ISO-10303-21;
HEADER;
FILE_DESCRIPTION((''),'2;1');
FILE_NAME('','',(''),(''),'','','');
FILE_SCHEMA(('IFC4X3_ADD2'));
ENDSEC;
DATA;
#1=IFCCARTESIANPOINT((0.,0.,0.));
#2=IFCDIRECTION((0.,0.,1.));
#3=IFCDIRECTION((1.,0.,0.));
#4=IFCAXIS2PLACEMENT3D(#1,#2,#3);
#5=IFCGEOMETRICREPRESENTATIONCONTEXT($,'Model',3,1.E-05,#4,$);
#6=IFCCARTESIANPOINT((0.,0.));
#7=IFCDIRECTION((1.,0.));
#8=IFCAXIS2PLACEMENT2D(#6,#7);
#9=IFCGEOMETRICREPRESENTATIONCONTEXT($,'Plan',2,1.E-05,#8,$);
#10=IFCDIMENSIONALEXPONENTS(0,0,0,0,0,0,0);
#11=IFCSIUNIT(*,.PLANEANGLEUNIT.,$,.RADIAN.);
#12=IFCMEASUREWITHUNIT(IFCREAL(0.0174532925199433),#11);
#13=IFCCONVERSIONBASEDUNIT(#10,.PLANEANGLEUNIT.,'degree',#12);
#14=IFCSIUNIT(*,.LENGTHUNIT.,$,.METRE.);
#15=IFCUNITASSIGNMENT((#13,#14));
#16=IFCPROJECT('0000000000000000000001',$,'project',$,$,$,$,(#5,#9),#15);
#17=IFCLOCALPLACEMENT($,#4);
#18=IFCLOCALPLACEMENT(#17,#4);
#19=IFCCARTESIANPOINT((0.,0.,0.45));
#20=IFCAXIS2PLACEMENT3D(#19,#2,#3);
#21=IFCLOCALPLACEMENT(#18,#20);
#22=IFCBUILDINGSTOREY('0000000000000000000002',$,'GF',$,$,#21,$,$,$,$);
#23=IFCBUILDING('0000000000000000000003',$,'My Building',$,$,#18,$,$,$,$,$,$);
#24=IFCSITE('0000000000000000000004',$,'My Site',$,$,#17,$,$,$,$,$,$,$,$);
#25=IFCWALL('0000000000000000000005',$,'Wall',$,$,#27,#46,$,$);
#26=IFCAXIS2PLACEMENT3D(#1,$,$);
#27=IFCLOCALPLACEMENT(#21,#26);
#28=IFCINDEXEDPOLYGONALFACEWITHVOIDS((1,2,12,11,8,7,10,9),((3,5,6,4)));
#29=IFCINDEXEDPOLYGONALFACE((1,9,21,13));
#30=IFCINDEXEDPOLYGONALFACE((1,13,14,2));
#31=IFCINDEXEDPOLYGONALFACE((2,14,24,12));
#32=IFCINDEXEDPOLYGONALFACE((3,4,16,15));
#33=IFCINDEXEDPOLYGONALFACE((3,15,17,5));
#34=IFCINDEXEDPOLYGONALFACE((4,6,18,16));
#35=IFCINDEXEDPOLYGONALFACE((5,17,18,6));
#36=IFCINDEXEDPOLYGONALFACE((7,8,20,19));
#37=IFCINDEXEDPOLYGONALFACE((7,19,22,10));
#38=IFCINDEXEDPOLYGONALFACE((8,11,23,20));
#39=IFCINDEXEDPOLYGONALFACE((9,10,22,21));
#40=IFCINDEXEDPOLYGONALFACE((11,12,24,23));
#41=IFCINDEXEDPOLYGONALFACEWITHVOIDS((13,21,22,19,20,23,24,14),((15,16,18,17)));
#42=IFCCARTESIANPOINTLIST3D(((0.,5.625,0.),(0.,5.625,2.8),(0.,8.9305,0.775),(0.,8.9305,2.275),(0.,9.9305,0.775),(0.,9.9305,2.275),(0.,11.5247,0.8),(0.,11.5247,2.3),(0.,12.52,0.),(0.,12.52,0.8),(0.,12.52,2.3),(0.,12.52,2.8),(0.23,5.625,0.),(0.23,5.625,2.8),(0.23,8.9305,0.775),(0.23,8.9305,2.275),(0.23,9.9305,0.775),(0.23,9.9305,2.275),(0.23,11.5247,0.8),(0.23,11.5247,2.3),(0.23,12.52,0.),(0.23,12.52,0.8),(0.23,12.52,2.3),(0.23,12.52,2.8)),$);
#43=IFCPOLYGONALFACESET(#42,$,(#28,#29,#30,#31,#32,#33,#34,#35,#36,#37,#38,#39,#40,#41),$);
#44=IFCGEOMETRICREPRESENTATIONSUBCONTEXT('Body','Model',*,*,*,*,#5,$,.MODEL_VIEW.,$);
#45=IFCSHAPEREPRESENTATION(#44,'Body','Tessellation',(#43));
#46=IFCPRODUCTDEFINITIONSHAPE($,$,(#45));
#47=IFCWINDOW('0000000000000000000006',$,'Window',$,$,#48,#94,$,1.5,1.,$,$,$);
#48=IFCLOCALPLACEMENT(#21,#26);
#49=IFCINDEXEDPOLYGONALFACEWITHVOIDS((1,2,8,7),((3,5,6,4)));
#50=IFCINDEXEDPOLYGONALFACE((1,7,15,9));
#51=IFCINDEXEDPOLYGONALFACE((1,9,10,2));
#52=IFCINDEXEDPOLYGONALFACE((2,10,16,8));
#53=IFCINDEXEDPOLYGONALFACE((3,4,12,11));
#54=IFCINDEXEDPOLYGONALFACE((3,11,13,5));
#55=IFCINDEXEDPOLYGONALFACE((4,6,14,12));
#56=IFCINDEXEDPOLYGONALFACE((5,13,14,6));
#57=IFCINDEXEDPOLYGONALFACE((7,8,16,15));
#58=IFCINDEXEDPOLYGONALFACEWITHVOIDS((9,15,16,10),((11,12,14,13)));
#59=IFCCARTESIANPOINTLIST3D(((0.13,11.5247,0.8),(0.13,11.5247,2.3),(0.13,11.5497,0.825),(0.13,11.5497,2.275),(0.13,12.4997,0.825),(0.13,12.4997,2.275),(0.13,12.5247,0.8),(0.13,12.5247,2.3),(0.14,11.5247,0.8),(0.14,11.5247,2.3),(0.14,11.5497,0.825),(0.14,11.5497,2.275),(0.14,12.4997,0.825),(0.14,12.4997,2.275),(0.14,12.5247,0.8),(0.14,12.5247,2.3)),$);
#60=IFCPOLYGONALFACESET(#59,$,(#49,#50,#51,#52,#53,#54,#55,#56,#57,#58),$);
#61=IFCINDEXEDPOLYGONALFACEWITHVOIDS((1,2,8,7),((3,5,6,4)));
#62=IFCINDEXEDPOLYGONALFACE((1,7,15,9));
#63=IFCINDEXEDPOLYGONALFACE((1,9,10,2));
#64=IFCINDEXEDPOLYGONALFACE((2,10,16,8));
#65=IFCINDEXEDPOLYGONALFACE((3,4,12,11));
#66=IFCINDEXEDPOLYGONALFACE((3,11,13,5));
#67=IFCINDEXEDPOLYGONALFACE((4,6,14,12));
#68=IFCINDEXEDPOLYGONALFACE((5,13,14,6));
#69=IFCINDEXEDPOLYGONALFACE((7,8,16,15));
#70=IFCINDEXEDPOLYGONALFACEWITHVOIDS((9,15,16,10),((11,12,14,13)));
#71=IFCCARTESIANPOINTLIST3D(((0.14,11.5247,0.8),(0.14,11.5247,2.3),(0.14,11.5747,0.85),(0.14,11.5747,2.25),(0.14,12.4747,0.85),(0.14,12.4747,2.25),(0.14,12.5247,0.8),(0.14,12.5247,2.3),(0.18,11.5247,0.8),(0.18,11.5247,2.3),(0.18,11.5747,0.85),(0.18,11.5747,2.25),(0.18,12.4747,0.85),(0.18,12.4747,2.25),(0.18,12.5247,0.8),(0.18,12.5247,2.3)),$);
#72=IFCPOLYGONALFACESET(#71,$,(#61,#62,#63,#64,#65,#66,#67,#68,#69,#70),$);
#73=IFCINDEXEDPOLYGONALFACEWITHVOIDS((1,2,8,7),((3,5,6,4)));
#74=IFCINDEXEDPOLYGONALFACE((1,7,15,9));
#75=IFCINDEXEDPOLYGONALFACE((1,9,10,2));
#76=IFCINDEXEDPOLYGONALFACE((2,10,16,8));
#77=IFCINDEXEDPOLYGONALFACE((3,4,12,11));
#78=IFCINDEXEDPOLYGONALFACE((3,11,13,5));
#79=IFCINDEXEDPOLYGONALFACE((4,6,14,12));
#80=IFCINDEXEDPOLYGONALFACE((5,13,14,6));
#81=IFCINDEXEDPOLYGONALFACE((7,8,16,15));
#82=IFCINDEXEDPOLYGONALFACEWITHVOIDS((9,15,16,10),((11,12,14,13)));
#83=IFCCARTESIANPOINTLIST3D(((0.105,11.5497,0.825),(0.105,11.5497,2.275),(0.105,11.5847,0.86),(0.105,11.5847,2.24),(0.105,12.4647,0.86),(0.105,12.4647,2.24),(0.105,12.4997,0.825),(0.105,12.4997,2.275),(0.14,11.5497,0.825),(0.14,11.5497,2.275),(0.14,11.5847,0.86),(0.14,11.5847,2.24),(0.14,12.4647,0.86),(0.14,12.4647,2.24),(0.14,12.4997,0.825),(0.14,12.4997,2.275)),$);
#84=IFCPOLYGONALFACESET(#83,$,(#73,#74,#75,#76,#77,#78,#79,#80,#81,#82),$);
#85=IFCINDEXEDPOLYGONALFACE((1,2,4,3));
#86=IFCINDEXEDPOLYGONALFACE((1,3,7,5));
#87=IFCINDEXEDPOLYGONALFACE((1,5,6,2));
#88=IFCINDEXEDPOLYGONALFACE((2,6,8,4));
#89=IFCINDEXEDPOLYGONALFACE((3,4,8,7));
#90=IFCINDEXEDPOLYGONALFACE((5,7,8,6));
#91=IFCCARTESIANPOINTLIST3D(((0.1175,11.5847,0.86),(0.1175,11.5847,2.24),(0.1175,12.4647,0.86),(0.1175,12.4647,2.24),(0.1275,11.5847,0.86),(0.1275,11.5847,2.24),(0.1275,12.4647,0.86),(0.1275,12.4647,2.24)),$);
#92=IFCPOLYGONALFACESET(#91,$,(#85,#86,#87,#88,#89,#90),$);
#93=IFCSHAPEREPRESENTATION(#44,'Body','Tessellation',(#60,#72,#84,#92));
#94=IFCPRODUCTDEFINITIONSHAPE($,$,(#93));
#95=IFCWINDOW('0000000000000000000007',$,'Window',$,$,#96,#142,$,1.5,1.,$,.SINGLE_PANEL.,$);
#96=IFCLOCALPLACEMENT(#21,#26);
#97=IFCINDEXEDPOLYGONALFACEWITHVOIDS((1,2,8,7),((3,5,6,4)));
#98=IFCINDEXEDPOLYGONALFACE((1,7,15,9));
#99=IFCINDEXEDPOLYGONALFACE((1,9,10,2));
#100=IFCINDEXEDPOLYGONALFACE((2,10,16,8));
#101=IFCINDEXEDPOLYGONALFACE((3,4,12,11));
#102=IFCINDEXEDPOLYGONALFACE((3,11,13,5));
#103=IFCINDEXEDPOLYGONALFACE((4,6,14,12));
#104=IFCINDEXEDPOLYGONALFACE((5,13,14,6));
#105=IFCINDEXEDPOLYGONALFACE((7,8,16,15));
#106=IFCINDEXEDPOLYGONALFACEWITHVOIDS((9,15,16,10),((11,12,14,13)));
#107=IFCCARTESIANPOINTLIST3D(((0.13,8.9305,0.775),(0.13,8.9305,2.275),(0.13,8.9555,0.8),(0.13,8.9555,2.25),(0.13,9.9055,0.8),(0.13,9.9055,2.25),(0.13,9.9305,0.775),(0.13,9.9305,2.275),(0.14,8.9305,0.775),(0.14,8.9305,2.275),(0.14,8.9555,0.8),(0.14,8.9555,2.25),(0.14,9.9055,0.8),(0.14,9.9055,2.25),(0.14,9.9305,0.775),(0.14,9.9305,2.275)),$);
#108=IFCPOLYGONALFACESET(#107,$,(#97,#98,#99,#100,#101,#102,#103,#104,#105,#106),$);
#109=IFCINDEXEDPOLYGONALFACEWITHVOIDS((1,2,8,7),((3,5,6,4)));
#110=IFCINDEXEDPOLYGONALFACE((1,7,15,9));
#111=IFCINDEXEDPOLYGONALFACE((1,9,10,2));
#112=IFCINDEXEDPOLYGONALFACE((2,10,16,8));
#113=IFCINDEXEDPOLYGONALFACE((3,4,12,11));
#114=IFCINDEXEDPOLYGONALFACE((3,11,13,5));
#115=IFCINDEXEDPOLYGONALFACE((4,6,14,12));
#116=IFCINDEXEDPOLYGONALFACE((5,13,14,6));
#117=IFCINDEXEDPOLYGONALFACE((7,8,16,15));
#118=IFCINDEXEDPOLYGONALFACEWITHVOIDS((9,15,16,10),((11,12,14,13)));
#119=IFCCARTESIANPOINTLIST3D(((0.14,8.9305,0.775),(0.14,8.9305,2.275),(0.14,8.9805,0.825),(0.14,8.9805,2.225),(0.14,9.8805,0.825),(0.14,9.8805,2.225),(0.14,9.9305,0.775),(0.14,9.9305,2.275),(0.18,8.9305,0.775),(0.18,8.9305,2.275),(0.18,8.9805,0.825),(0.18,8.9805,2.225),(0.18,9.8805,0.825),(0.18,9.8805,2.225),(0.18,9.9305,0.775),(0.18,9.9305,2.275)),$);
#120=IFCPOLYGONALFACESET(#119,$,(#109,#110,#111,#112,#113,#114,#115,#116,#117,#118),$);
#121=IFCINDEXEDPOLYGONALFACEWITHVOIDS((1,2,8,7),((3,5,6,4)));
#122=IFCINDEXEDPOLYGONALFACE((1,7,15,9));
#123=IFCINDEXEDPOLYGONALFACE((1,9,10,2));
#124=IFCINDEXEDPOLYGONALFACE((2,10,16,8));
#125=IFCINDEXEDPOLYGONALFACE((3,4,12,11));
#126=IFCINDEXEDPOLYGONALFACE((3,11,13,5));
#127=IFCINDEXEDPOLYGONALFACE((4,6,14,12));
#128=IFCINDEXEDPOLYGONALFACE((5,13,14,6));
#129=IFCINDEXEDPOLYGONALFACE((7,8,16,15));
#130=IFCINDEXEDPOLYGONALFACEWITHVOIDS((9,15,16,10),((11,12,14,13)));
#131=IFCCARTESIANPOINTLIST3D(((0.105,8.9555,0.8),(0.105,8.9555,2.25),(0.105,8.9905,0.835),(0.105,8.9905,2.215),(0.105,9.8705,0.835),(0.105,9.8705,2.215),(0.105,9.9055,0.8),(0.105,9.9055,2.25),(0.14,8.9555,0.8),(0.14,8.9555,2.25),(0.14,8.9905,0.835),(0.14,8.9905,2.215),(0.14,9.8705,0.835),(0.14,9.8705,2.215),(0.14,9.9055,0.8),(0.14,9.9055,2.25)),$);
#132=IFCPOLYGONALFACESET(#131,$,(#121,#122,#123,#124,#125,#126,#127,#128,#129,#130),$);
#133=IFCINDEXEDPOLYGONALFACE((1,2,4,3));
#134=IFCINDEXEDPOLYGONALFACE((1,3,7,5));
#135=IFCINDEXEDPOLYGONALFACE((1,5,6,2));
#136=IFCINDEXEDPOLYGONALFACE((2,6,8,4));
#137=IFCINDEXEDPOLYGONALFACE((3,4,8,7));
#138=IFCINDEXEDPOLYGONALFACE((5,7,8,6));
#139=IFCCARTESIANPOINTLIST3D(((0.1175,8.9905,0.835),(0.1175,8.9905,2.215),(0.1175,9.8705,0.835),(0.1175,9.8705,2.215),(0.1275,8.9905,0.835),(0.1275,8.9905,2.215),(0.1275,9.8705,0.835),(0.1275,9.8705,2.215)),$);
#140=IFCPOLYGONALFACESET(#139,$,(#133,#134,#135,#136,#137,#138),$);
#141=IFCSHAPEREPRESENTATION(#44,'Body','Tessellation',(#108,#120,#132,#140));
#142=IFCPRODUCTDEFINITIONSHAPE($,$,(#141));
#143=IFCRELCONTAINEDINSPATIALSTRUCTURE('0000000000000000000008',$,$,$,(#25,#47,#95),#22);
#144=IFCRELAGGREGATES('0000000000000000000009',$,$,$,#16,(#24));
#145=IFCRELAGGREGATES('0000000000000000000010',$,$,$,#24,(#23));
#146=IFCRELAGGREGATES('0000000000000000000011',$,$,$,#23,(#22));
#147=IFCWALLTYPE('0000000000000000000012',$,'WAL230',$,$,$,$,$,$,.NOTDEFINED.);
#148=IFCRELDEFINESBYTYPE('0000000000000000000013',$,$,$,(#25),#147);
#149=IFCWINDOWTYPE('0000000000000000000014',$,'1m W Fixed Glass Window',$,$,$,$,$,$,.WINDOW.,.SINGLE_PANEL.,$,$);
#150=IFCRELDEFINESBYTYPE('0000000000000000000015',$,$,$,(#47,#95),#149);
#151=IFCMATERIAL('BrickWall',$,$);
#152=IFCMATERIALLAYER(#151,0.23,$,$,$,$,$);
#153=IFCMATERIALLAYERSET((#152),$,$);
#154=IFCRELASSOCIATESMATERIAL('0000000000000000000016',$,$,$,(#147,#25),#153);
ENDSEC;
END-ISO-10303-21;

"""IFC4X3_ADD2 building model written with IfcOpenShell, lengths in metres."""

from ifc_helpers import new_model, entity, si_unit, converted_unit, frame, origin_with_axes, origin_2d_with_axis, place, context, subcontext, project, spatial, line, indexed_curve, outline, extrude, shape, source, transform, mapped, material, layer, layer_set, layer_usage, type_object, type_shapes, element, fill, save


model = new_model("IFC4X3_ADD2")

# Units and contexts
model_context = context("Model", 3, precision=1e-05, world=origin_with_axes())
plan_context = context("Plan", 2, precision=1e-05, world=origin_2d_with_axis())
body_context_1 = subcontext(model_context, "Body", "Model", "MODEL_VIEW")
body_context_2 = subcontext(plan_context, "Body", "Plan", "PLAN_VIEW")
ifc_project = project(units=[converted_unit("PLANEANGLEUNIT", "degree", entity("IfcReal", 0.0174532925199433), si_unit("PLANEANGLEUNIT", "RADIAN"), dimensions=[0, 0, 0, 0, 0, 0, 0]), si_unit("LENGTHUNIT", "METRE")], contexts=[model_context, plan_context])

# Site, building, storey
site_placement = place(None, origin_with_axes())
site = spatial("IfcSite", under=ifc_project, at=site_placement, Name="My Site")
building_placement = place(site_placement, origin_with_axes())
building = spatial("IfcBuilding", under=site, at=building_placement, Name="My Building")
storey_placement = place(building_placement, frame((0.0, 0.0, 0.45), z_axis=(0.0, 0.0, 1.0), x_axis=(1.0, 0.0, 0.0)))
storey = spatial("IfcBuildingStorey", under=building, at=storey_placement, Name="GF")

# Wall, openings, windows
ifc_material_1 = material(Name="BrickWall")
ifc_layer_1 = layer(ifc_material_1, 0.23)
ifc_layer_set_1 = layer_set([ifc_layer_1])
wall_type_1 = type_object("IfcWallType", Name="WAL230", PredefinedType="NOTDEFINED", material=ifc_layer_set_1)
shared_shape_1 = source(origin_with_axes(), body_context_1, "Body", "SweptSolid", [
    extrude(outline(indexed_curve([(0.0, 0.0), (1.0, 0.0), (1.0, 1.5), (0.0, 1.5)], segments=[line(1, 2, 3, 4, 1)])), frame((0.0, -0.6, 0.0), z_axis=(0.0, -1.0, 0.0), x_axis=(1.0, 0.0, 0.0)), (0.0, 0.0, -1.0), 1.2),
])
window_type_1 = type_object("IfcWindowType", Name="1m W Fixed Glass Window", PartitioningType="SINGLE_PANEL", PredefinedType="WINDOW")
shared_shape_2 = source(origin_with_axes(), body_context_1, "Body", "SweptSolid", [
    extrude(outline(indexed_curve([(0.0, 0.0), (1.0, 0.0), (1.0, 1.5), (0.0, 1.5)], segments=[line(1, 2, 3, 4, 1)]), holes=[indexed_curve([(0.025, 0.025), (0.975, 0.025), (0.975, 1.475), (0.025, 1.475)], segments=[line(1, 2, 3, 4, 1)])]), frame((0.0, 0.09, 0.0), z_axis=(0.0, -1.0, 0.0), x_axis=(1.0, 0.0, 0.0)), (0.0, 0.0, -1.0), 0.01),
    extrude(outline(indexed_curve([(0.0, 0.0), (1.0, 0.0), (1.0, 1.5), (0.0, 1.5)], segments=[line(1, 2, 3, 4, 1)]), holes=[indexed_curve([(0.05, 0.05), (0.95, 0.05), (0.95, 1.45), (0.05, 1.45)], segments=[line(1, 2, 3, 4, 1)])]), frame((0.0, 0.05, 0.0), z_axis=(0.0, -1.0, 0.0), x_axis=(1.0, 0.0, 0.0)), (0.0, 0.0, -1.0), 0.04),
    extrude(outline(indexed_curve([(0.0, 0.0), (0.95, 0.0), (0.95, 1.45), (0.0, 1.45)], segments=[line(1, 2, 3, 4, 1)]), holes=[indexed_curve([(0.035, 0.035), (0.915, 0.035), (0.915, 1.415), (0.035, 1.415)], segments=[line(1, 2, 3, 4, 1)])]), frame((0.025, 0.09, 0.025), z_axis=(0.0, -1.0, 0.0), x_axis=(1.0, 0.0, 0.0)), (0.0, 0.0, -1.0), 0.035),
    extrude(outline(indexed_curve([(0.035, 0.035), (0.915, 0.035), (0.915, 1.415), (0.035, 1.415)], segments=[line(1, 2, 3, 4, 1)])), frame((0.025, 0.1025, 0.025), z_axis=(0.0, -1.0, 0.0), x_axis=(1.0, 0.0, 0.0)), (0.0, 0.0, -1.0), 0.01),
])
shared_shape_3 = source(origin_with_axes(), body_context_2, "Body", "Curve2D", [
    entity("IfcIndexedPolyCurve", entity("IfcCartesianPointList2D", [[0.05, 0.05], [0.95, 0.05]])),
    entity("IfcIndexedPolyCurve", entity("IfcCartesianPointList2D", [[0.0, 0.1], [0.025, 0.1], [0.025, 0.09], [0.05, 0.09], [0.05, 0.05], [0.0, 0.05]]), [entity("IfcLineIndex", [1, 2, 3, 4, 5, 6, 1])]),
    entity("IfcIndexedPolyCurve", entity("IfcCartesianPointList2D", [[1.0, 0.1], [0.975, 0.1], [0.975, 0.09], [0.95, 0.09], [0.95, 0.05], [1.0, 0.05]]), [entity("IfcLineIndex", [1, 2, 3, 4, 5, 6, 1])]),
    entity("IfcIndexedPolyCurve", entity("IfcCartesianPointList2D", [[0.025, 0.09], [0.06, 0.09], [0.06, 0.125], [0.025, 0.125]]), [entity("IfcLineIndex", [1, 2, 3, 4, 1])]),
    entity("IfcIndexedPolyCurve", entity("IfcCartesianPointList2D", [[0.975, 0.09], [0.94, 0.09], [0.94, 0.125], [0.975, 0.125]]), [entity("IfcLineIndex", [1, 2, 3, 4, 1])]),
    entity("IfcIndexedPolyCurve", entity("IfcCartesianPointList2D", [[0.06, 0.09], [0.94, 0.09]])),
    entity("IfcIndexedPolyCurve", entity("IfcCartesianPointList2D", [[0.06, 0.125], [0.94, 0.125]])),
    entity("IfcIndexedPolyCurve", entity("IfcCartesianPointList2D", [[0.06, 0.1075], [0.94, 0.1075]])),
])
type_shapes(window_type_1, [shared_shape_2, shared_shape_3])
ifc_layer_usage_1 = layer_usage(ifc_layer_set_1, "AXIS2", "POSITIVE", 0.0)
wall_1_placement = place(storey_placement, frame((0.23, 5.625, 0.0), z_axis=(0.0, 0.0, 1.0), x_axis=(0.0, 1.0, 0.0)))
wall_1 = element("IfcWall", 1, at=wall_1_placement, inside=storey, type_object=wall_type_1, material=ifc_layer_usage_1, Name="Wall", context=body_context_1, shape_type="SweptSolid", body=[
    extrude(outline(indexed_curve([(0.0, 0.0), (0.0, 0.23), (6.895, 0.23), (6.895, 0.0), (0.0, 0.0)], self_intersect=False)), origin_with_axes(), (0.0, 0.0, 1.0), 2.8),
])
opening_1_placement = place(wall_1_placement, frame((5.8997, 0.0, 0.8), z_axis=(0.0, 0.0, 1.0), x_axis=(1.0, 0.0, 0.0)))
opening_1 = element("IfcOpeningElement", 2, at=opening_1_placement, cuts=wall_1, PredefinedType="OPENING", context=body_context_1, shape_type="MappedRepresentation", body=[
    mapped(shared_shape_1, transform((0.0, 0.0, 0.0), x_axis=(1.0, 0.0, 0.0), y_axis=(0.0, 1.0, 0.0), z_axis=(0.0, 0.0, 1.0), scale=1.0)),
])
opening_2_placement = place(wall_1_placement, frame((3.3055, 0.0, 0.775), z_axis=(0.0, 0.0, 1.0), x_axis=(1.0, 0.0, 0.0)))
opening_2 = element("IfcOpeningElement", 3, at=opening_2_placement, cuts=wall_1, PredefinedType="OPENING", context=body_context_1, shape_type="MappedRepresentation", body=[
    mapped(shared_shape_1, transform((0.0, 0.0, 0.0), x_axis=(1.0, 0.0, 0.0), y_axis=(0.0, 1.0, 0.0), z_axis=(0.0, 0.0, 1.0), scale=1.0)),
])
window_1_placement = place(opening_1_placement, frame((0.0, 0.0, 0.0), z_axis=(0.0, 0.0, 1.0), x_axis=(1.0, 0.0, 0.0)))
window_1 = element("IfcWindow", 4, at=window_1_placement, inside=storey, type_object=window_type_1, Name="Window", OverallHeight=1.5, OverallWidth=1.0, shapes=[
    shape(body_context_1, "Body", "MappedRepresentation", [mapped(shared_shape_2, transform((0.0, 0.0, 0.0), x_axis=(1.0, 0.0, 0.0), y_axis=(0.0, 1.0, 0.0), z_axis=(0.0, 0.0, 1.0), scale=1.0))]),
    shape(body_context_2, "Body", "MappedRepresentation", [mapped(shared_shape_3, transform((0.0, 0.0, 0.0), x_axis=(1.0, 0.0, 0.0), y_axis=(0.0, 1.0, 0.0), z_axis=(0.0, 0.0, 1.0), scale=1.0))]),
])
fill(opening_1, window_1)
window_2_placement = place(opening_2_placement, frame((0.0, 0.0, 0.0), z_axis=(0.0, 0.0, 1.0), x_axis=(1.0, 0.0, 0.0)))
window_2 = element("IfcWindow", 5, at=window_2_placement, inside=storey, type_object=window_type_1, Name="Window", OverallHeight=1.5, OverallWidth=1.0, PartitioningType="SINGLE_PANEL", shapes=[
    shape(body_context_1, "Body", "MappedRepresentation", [mapped(shared_shape_2, transform((0.0, 0.0, 0.0), x_axis=(1.0, 0.0, 0.0), y_axis=(0.0, 1.0, 0.0), z_axis=(0.0, 0.0, 1.0), scale=1.0))]),
    shape(body_context_2, "Body", "MappedRepresentation", [mapped(shared_shape_3, transform((0.0, 0.0, 0.0), x_axis=(1.0, 0.0, 0.0), y_axis=(0.0, 1.0, 0.0), z_axis=(0.0, 0.0, 1.0), scale=1.0))]),
])
fill(opening_2, window_2)

save(model, "model.ifc")
